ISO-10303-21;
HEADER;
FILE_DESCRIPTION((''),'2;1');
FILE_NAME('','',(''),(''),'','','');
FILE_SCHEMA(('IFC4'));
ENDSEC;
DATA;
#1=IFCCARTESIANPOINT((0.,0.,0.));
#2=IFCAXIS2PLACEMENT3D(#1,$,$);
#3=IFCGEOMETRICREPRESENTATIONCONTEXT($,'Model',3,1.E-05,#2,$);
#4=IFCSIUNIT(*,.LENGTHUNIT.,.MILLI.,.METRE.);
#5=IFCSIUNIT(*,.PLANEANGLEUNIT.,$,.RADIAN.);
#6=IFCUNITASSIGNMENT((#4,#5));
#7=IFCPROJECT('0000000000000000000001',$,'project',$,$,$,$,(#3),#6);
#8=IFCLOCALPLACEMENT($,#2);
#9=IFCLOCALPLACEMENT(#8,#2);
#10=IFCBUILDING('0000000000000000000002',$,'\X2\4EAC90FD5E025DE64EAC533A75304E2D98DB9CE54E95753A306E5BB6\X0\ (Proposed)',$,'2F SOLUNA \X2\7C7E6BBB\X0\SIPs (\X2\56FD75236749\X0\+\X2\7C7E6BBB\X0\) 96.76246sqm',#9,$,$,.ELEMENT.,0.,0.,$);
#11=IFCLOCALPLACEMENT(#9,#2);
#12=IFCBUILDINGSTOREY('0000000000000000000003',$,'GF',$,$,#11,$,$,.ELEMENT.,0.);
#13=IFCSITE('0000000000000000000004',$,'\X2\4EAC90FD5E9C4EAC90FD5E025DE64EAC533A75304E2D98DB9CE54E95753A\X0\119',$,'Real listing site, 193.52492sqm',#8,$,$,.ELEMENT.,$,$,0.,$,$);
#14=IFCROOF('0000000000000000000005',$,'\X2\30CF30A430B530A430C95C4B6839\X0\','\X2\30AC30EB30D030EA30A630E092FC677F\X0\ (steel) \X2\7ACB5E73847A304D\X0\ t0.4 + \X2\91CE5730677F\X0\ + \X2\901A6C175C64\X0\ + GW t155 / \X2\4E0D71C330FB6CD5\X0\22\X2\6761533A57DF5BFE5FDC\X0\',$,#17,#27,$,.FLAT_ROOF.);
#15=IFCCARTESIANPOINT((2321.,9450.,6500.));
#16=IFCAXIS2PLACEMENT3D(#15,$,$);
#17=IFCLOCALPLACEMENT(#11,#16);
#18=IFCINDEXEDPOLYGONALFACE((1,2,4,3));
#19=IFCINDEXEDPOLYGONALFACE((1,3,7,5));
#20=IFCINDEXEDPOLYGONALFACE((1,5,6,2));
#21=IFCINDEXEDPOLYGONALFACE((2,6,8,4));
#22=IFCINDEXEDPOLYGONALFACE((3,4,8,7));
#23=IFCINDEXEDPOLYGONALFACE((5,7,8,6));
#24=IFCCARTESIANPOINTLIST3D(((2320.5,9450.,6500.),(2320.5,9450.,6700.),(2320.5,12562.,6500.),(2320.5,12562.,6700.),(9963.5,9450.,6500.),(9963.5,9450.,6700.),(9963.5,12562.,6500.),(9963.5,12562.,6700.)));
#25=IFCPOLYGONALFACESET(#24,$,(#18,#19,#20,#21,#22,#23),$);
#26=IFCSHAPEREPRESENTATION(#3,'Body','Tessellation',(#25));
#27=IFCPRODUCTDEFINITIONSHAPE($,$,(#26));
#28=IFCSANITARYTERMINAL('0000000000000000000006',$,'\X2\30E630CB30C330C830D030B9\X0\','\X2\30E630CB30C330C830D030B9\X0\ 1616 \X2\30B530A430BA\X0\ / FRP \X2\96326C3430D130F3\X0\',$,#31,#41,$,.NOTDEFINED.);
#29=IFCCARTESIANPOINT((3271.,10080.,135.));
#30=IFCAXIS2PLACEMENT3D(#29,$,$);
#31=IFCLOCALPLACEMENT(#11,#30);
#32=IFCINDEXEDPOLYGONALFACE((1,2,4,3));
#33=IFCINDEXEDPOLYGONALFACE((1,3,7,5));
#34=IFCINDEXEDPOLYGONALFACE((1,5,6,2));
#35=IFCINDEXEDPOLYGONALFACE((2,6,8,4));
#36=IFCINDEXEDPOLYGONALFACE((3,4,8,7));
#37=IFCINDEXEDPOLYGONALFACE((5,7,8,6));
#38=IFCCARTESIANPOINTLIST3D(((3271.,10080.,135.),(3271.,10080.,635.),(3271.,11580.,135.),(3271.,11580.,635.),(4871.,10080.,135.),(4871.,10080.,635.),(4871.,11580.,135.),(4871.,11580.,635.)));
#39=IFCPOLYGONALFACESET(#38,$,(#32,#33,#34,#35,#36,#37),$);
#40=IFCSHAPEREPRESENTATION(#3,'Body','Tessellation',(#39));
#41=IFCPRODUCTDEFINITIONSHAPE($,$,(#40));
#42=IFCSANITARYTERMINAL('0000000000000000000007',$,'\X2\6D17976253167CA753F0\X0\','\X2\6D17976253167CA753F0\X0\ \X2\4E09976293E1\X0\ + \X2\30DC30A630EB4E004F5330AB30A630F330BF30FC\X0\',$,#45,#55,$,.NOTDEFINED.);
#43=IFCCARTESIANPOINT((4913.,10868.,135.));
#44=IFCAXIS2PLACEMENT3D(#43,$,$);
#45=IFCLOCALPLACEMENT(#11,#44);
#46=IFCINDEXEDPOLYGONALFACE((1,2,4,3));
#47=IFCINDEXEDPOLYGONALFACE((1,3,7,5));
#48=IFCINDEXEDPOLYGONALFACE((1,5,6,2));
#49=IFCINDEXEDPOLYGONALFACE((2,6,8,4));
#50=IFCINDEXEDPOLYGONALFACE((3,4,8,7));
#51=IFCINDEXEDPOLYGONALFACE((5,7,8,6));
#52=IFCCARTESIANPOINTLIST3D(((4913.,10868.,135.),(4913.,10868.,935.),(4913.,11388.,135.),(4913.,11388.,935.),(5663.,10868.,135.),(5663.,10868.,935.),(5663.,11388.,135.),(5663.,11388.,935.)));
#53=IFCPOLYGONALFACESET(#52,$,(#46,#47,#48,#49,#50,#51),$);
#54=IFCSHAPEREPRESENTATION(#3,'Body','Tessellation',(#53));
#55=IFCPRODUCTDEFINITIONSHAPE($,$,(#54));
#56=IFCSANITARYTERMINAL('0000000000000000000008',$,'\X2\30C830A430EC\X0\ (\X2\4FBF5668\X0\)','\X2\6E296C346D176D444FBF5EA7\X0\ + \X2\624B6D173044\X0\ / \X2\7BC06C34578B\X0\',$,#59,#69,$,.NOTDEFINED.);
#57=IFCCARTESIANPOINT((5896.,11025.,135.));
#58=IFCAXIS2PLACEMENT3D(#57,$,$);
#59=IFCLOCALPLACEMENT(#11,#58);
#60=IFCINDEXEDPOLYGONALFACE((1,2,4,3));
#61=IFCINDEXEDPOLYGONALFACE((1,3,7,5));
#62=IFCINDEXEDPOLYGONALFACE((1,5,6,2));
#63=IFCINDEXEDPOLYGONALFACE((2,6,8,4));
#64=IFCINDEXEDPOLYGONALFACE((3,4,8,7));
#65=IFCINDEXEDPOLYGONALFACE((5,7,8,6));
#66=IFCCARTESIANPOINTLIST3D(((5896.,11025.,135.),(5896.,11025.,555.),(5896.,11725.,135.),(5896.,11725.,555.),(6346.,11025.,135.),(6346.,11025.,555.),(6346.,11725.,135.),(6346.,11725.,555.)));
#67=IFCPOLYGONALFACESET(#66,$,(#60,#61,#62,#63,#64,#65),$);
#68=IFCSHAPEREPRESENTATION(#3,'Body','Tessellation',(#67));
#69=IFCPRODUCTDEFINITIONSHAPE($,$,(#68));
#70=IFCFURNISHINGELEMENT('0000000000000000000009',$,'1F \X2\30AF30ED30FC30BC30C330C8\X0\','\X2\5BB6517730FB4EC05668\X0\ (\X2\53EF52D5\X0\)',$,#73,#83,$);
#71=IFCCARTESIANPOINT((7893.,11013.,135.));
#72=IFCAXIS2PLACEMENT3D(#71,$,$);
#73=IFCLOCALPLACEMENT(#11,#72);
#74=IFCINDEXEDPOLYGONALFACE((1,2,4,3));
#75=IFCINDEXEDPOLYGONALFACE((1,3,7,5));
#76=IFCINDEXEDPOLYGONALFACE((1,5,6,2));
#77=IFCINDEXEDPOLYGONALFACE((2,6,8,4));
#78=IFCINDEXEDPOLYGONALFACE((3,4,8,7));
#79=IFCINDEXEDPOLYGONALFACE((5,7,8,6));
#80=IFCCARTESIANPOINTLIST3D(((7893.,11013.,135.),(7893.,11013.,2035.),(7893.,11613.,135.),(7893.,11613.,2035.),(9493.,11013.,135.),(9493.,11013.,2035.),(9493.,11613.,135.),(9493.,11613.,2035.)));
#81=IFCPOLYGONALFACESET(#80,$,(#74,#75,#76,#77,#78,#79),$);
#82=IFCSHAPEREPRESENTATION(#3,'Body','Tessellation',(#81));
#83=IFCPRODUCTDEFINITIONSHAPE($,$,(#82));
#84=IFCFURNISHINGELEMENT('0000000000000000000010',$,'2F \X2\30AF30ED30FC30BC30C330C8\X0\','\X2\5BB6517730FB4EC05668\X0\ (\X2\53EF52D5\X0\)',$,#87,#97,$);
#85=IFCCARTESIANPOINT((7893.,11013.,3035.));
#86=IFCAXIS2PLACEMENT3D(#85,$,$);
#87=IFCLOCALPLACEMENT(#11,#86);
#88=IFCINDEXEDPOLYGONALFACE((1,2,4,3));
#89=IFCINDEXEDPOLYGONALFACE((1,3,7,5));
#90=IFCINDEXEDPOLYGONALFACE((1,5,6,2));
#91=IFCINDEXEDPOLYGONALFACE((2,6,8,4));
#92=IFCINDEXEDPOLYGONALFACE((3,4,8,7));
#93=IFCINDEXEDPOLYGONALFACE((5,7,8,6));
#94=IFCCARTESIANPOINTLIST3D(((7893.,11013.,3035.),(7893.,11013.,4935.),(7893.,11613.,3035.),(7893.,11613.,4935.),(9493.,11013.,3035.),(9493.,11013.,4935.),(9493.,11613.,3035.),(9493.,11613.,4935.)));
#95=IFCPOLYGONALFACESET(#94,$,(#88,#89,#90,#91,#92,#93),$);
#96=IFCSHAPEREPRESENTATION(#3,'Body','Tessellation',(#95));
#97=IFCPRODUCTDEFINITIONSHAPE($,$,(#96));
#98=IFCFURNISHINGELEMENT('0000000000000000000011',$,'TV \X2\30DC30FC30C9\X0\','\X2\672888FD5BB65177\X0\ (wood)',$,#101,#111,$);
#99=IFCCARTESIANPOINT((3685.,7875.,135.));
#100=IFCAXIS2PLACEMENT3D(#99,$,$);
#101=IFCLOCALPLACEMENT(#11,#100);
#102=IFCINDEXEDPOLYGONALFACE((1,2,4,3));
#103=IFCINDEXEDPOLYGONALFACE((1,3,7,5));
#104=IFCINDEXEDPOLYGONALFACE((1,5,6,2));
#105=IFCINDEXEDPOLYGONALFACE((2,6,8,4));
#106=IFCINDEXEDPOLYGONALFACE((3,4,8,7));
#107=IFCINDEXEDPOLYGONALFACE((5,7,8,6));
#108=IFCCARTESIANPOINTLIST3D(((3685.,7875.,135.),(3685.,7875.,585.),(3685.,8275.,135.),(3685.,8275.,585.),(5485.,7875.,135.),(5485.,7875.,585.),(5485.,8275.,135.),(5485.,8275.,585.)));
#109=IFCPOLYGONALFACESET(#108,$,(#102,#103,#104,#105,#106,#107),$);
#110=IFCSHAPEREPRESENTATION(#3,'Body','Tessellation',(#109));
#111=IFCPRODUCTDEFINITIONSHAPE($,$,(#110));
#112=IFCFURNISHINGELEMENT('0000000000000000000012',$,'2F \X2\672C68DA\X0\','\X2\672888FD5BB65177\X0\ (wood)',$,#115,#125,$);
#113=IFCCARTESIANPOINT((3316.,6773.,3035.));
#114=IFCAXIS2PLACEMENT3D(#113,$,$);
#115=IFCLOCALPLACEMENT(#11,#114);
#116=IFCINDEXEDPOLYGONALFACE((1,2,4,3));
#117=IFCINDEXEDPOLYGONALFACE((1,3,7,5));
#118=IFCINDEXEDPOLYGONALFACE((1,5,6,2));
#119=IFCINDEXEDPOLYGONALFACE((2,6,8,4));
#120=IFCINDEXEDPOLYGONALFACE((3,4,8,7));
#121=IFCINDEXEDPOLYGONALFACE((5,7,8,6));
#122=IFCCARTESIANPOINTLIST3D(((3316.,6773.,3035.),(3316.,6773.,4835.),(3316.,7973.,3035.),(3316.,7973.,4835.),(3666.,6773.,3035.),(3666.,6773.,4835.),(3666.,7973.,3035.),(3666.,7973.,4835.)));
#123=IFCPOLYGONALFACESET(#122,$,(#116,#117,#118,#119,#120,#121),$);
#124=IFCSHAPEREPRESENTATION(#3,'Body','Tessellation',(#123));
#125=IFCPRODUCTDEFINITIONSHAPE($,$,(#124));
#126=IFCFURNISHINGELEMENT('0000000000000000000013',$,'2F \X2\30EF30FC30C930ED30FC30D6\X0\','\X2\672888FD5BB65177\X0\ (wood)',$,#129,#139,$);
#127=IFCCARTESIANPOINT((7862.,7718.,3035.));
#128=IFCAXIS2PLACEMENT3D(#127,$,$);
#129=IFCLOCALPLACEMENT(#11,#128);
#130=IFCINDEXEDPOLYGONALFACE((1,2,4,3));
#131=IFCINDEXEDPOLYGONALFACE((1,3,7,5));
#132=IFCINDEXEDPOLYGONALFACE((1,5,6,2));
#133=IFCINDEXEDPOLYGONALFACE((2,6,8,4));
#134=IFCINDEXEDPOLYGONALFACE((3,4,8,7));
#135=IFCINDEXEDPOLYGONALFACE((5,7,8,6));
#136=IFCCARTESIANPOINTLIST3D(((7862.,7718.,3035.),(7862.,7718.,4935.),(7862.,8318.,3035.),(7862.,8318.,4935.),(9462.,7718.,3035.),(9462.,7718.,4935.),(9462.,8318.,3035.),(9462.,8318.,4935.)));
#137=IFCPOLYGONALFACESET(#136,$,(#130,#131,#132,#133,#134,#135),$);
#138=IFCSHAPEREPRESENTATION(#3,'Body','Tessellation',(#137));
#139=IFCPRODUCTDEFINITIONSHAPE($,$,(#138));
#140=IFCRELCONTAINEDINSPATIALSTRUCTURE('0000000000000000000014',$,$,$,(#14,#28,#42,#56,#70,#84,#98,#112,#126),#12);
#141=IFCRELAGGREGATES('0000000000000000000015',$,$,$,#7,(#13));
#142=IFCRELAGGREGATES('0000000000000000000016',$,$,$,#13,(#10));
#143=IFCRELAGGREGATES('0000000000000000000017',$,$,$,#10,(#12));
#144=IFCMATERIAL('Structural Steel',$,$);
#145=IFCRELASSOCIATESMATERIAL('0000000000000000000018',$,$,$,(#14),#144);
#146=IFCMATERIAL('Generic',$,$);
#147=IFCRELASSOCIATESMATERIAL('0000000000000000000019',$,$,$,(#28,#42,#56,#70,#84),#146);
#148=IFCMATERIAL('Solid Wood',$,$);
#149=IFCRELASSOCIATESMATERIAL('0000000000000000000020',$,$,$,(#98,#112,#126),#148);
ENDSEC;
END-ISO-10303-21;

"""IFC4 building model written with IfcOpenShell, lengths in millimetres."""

from ifc_helpers import new_model, si_unit, frame, frame_2d, origin, place, context, project, spatial, rectangle, extrude, material, element, save


model = new_model("IFC4")

# Units and contexts
model_context = context("Model", 3, precision=1e-05, world=origin())
ifc_project = project(units=[si_unit("LENGTHUNIT", "METRE", prefix="MILLI"), si_unit("PLANEANGLEUNIT", "RADIAN")], contexts=[model_context])

# Site, building, storey
site_placement = place(None, origin())
site = spatial("IfcSite", under=ifc_project, at=site_placement, Name="京都府京都市左京区田中飛鳥井町119", ObjectType="Real listing site, 193.52492sqm", CompositionType="ELEMENT", RefElevation=0.0)
building_placement = place(site_placement, origin())
building = spatial("IfcBuilding", under=site, at=building_placement, Name="京都市左京区田中飛鳥井町の家 (Proposed)", ObjectType="2F SOLUNA 籾殻SIPs (国産杉+籾殻) 96.76246sqm", CompositionType="ELEMENT", ElevationOfRefHeight=0.0, ElevationOfTerrain=0.0)
storey_placement = place(building_placement, origin())
storey = spatial("IfcBuildingStorey", under=building, at=storey_placement, Name="GF", CompositionType="ELEMENT", Elevation=0.0)

# Shared definitions
ifc_material_1 = material(Name="Solid Wood")

# Roof
ifc_material_2 = material(Name="Structural Steel")
roof_placement = place(storey_placement, frame((2321.0, 9450.0, 6500.0)))
element("IfcRoof", 1, at=roof_placement, inside=storey, material=ifc_material_2, Name="ハイサイド屋根", Description="ガルバリウム鋼板 (steel) 立平葺き t0.4 + 野地板 + 通気層 + GW t155 / 不燃・法22条区域対応", PredefinedType="FLAT_ROOF", context=model_context, shape_type="SweptSolid", body=[
    extrude(rectangle(XDim=7643.0, YDim=3112.0, at=frame_2d((3821.0, 1556.0))), frame((2321.0, 9450.0, 6500.0)), (0.0, 0.0, 1.0), 200.0),
])

# Sanitary terminals
ifc_material_3 = material(Name="Generic")
sanitary_terminal_1_placement = place(storey_placement, frame((3271.0, 10080.0, 135.0)))
element("IfcSanitaryTerminal", 2, at=sanitary_terminal_1_placement, inside=storey, material=ifc_material_3, Name="ユニットバス", Description="ユニットバス 1616 サイズ / FRP 防水パン", PredefinedType="NOTDEFINED", context=model_context, shape_type="SweptSolid", body=[
    extrude(rectangle(XDim=1600.0, YDim=1500.0, at=frame_2d((800.0, 750.0))), frame((3271.0, 10080.0, 135.0)), (0.0, 0.0, 1.0), 500.0),
])
sanitary_terminal_2_placement = place(storey_placement, frame((4913.0, 10868.0, 135.0)))
element("IfcSanitaryTerminal", 3, at=sanitary_terminal_2_placement, inside=storey, material=ifc_material_3, Name="洗面化粧台", Description="洗面化粧台 三面鏡 + ボウル一体カウンター", PredefinedType="NOTDEFINED", context=model_context, shape_type="SweptSolid", body=[
    extrude(rectangle(XDim=750.0, YDim=520.0, at=frame_2d((375.0, 260.0))), frame((4913.0, 10868.0, 135.0)), (0.0, 0.0, 1.0), 800.0),
])
sanitary_terminal_3_placement = place(storey_placement, frame((5896.0, 11025.0, 135.0)))
element("IfcSanitaryTerminal", 4, at=sanitary_terminal_3_placement, inside=storey, material=ifc_material_3, Name="トイレ (便器)", Description="温水洗浄便座 + 手洗い / 節水型", PredefinedType="NOTDEFINED", context=model_context, shape_type="SweptSolid", body=[
    extrude(rectangle(XDim=450.0, YDim=700.0, at=frame_2d((225.0, 350.0))), frame((5896.0, 11025.0, 135.0)), (0.0, 0.0, 1.0), 420.0),
])

# Furnishing elements
furnishing_1_placement = place(storey_placement, frame((7893.0, 11013.0, 135.0)))
element("IfcFurnishingElement", 5, at=furnishing_1_placement, inside=storey, material=ifc_material_3, Name="1F クローゼット", Description="家具・什器 (可動)", context=model_context, shape_type="SweptSolid", body=[
    extrude(rectangle(XDim=1600.0, YDim=600.0, at=frame_2d((800.0, 300.0))), frame((7893.0, 11013.0, 135.0)), (0.0, 0.0, 1.0), 1900.0),
])
furnishing_2_placement = place(storey_placement, frame((7893.0, 11013.0, 3035.0)))
element("IfcFurnishingElement", 6, at=furnishing_2_placement, inside=storey, material=ifc_material_3, Name="2F クローゼット", Description="家具・什器 (可動)", context=model_context, shape_type="SweptSolid", body=[
    extrude(rectangle(XDim=1600.0, YDim=600.0, at=frame_2d((800.0, 300.0))), frame((7893.0, 11013.0, 3035.0)), (0.0, 0.0, 1.0), 1900.0),
])
furnishing_3_placement = place(storey_placement, frame((3685.0, 7875.0, 135.0)))
element("IfcFurnishingElement", 7, at=furnishing_3_placement, inside=storey, material=ifc_material_1, Name="TV ボード", Description="木製家具 (wood)", context=model_context, shape_type="SweptSolid", body=[
    extrude(rectangle(XDim=1800.0, YDim=400.0, at=frame_2d((900.0, 200.0))), frame((3685.0, 7875.0, 135.0)), (0.0, 0.0, 1.0), 450.0),
])
furnishing_4_placement = place(storey_placement, frame((3316.0, 6773.0, 3035.0)))
element("IfcFurnishingElement", 8, at=furnishing_4_placement, inside=storey, material=ifc_material_1, Name="2F 本棚", Description="木製家具 (wood)", context=model_context, shape_type="SweptSolid", body=[
    extrude(rectangle(XDim=350.0, YDim=1200.0, at=frame_2d((175.0, 600.0))), frame((3316.0, 6773.0, 3035.0)), (0.0, 0.0, 1.0), 1800.0),
])
furnishing_5_placement = place(storey_placement, frame((7862.0, 7718.0, 3035.0)))
element("IfcFurnishingElement", 9, at=furnishing_5_placement, inside=storey, material=ifc_material_1, Name="2F ワードローブ", Description="木製家具 (wood)", context=model_context, shape_type="SweptSolid", body=[
    extrude(rectangle(XDim=1600.0, YDim=600.0, at=frame_2d((800.0, 300.0))), frame((7862.0, 7718.0, 3035.0)), (0.0, 0.0, 1.0), 1900.0),
])

save(model, "model.ifc")
